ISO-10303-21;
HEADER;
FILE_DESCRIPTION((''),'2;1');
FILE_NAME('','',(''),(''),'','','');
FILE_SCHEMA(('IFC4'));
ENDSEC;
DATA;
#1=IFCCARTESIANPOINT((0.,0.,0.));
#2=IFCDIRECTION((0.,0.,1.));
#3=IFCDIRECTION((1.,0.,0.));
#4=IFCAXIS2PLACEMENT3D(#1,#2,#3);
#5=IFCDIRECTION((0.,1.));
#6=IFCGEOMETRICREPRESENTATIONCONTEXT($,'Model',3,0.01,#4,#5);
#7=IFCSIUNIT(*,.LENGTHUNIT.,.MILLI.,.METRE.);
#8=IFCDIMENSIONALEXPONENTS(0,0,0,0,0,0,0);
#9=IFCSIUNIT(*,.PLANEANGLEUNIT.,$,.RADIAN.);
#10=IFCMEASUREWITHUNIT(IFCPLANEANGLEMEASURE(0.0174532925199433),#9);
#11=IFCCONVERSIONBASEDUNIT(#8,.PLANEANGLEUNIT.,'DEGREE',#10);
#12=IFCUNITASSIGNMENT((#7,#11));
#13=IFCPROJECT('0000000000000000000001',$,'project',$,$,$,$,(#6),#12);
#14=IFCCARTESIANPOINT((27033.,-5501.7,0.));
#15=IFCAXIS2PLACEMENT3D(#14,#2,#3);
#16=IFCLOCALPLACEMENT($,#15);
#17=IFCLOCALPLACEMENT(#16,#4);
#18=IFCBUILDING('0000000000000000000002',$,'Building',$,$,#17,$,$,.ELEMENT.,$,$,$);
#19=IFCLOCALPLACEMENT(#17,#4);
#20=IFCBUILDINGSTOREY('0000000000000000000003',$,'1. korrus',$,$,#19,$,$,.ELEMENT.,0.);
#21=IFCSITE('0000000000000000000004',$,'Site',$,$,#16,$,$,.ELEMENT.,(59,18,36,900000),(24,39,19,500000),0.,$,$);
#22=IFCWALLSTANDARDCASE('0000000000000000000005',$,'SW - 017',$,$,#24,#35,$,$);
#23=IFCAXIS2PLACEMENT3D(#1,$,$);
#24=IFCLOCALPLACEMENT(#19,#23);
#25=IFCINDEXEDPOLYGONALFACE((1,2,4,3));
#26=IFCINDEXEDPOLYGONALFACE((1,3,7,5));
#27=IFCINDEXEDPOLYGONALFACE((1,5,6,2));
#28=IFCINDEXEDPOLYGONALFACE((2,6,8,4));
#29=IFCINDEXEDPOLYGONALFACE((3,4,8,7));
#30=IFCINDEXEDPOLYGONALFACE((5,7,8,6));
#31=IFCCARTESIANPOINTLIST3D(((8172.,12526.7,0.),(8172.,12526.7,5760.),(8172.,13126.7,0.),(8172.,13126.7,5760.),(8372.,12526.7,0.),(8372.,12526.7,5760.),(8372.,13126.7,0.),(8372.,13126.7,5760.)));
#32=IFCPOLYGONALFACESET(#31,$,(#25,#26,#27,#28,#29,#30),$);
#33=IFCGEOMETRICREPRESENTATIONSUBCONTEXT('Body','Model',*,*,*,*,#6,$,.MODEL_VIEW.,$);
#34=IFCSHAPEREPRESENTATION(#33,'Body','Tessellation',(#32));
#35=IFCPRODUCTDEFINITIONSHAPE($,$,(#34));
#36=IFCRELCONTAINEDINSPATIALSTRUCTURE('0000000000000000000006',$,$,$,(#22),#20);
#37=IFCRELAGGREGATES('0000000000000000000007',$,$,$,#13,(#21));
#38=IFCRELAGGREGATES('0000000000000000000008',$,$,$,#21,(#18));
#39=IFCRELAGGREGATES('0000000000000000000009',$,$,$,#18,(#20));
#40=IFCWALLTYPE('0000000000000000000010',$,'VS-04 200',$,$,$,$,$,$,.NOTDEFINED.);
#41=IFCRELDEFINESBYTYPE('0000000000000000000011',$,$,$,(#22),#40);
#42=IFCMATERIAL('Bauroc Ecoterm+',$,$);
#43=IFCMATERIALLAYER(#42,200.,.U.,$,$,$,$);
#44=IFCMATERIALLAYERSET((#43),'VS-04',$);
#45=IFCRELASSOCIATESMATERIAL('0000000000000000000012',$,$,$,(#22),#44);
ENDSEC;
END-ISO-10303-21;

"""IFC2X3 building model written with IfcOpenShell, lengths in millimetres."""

from ifc_helpers import new_model, entity, si_unit, converted_unit, direction, frame, origin_with_axes, place, context, subcontext, project, spatial, polyline, outline, extrude, material, layer, layer_set, layer_usage, type_object, element, save


model = new_model("IFC2X3")

# Units and contexts
model_context = context("Model", 3, precision=0.01, world=origin_with_axes(), true_north=direction((0.0, 1.0)))
body_context = subcontext(model_context, "Body", "Model", "MODEL_VIEW")
ifc_project = project(units=[si_unit("LENGTHUNIT", "METRE", prefix="MILLI"), converted_unit("PLANEANGLEUNIT", "DEGREE", entity("IfcPlaneAngleMeasure", 0.0174532925199433), si_unit("PLANEANGLEUNIT", "RADIAN"), dimensions=[0, 0, 0, 0, 0, 0, 0])], contexts=[model_context])

# Site, building, storey
site_placement = place(None, frame((27033.0, -5501.7, 0.0), z_axis=(0.0, 0.0, 1.0), x_axis=(1.0, 0.0, 0.0)))
site = spatial("IfcSite", under=ifc_project, at=site_placement, Name="Site", CompositionType="ELEMENT", RefLatitude=(59, 18, 36, 900000), RefLongitude=(24, 39, 19, 500000), RefElevation=0.0)
building_placement = place(site_placement, origin_with_axes())
building = spatial("IfcBuilding", under=site, at=building_placement, Name="Building", CompositionType="ELEMENT")
storey_placement = place(building_placement, origin_with_axes())
storey = spatial("IfcBuildingStorey", under=building, at=storey_placement, Name="1. korrus", CompositionType="ELEMENT", Elevation=0.0)

# Shared definitions
ifc_material_1 = material(Name="Bauroc Ecoterm+")

# Wall
ifc_layer_1 = layer(ifc_material_1, 200.0, ventilated="UNKNOWN")
ifc_layer_set_1 = layer_set([ifc_layer_1], Name="VS-04")
ifc_layer_usage_1 = layer_usage(ifc_layer_set_1, "AXIS2", "POSITIVE", 0.0)
wall_type_1 = type_object("IfcWallType", Name="VS-04 200", PredefinedType="NOTDEFINED")
wall_1_placement = place(storey_placement, frame((8172.0, 13126.7, 0.0), z_axis=(0.0, 0.0, 1.0), x_axis=(0.0, -1.0, 0.0)))
element("IfcWallStandardCase", 1, at=wall_1_placement, inside=storey, type_object=wall_type_1, material=ifc_layer_usage_1, Name="SW - 017", context=body_context, shape_type="SweptSolid", body=[
    extrude(outline(polyline([(0.0, 0.0), (600.0, 0.0), (600.0, 200.0), (0.0, 200.0), (0.0, 0.0)])), origin_with_axes(), (0.0, 0.0, 1.0), 5760.0),
])

save(model, "model.ifc")
